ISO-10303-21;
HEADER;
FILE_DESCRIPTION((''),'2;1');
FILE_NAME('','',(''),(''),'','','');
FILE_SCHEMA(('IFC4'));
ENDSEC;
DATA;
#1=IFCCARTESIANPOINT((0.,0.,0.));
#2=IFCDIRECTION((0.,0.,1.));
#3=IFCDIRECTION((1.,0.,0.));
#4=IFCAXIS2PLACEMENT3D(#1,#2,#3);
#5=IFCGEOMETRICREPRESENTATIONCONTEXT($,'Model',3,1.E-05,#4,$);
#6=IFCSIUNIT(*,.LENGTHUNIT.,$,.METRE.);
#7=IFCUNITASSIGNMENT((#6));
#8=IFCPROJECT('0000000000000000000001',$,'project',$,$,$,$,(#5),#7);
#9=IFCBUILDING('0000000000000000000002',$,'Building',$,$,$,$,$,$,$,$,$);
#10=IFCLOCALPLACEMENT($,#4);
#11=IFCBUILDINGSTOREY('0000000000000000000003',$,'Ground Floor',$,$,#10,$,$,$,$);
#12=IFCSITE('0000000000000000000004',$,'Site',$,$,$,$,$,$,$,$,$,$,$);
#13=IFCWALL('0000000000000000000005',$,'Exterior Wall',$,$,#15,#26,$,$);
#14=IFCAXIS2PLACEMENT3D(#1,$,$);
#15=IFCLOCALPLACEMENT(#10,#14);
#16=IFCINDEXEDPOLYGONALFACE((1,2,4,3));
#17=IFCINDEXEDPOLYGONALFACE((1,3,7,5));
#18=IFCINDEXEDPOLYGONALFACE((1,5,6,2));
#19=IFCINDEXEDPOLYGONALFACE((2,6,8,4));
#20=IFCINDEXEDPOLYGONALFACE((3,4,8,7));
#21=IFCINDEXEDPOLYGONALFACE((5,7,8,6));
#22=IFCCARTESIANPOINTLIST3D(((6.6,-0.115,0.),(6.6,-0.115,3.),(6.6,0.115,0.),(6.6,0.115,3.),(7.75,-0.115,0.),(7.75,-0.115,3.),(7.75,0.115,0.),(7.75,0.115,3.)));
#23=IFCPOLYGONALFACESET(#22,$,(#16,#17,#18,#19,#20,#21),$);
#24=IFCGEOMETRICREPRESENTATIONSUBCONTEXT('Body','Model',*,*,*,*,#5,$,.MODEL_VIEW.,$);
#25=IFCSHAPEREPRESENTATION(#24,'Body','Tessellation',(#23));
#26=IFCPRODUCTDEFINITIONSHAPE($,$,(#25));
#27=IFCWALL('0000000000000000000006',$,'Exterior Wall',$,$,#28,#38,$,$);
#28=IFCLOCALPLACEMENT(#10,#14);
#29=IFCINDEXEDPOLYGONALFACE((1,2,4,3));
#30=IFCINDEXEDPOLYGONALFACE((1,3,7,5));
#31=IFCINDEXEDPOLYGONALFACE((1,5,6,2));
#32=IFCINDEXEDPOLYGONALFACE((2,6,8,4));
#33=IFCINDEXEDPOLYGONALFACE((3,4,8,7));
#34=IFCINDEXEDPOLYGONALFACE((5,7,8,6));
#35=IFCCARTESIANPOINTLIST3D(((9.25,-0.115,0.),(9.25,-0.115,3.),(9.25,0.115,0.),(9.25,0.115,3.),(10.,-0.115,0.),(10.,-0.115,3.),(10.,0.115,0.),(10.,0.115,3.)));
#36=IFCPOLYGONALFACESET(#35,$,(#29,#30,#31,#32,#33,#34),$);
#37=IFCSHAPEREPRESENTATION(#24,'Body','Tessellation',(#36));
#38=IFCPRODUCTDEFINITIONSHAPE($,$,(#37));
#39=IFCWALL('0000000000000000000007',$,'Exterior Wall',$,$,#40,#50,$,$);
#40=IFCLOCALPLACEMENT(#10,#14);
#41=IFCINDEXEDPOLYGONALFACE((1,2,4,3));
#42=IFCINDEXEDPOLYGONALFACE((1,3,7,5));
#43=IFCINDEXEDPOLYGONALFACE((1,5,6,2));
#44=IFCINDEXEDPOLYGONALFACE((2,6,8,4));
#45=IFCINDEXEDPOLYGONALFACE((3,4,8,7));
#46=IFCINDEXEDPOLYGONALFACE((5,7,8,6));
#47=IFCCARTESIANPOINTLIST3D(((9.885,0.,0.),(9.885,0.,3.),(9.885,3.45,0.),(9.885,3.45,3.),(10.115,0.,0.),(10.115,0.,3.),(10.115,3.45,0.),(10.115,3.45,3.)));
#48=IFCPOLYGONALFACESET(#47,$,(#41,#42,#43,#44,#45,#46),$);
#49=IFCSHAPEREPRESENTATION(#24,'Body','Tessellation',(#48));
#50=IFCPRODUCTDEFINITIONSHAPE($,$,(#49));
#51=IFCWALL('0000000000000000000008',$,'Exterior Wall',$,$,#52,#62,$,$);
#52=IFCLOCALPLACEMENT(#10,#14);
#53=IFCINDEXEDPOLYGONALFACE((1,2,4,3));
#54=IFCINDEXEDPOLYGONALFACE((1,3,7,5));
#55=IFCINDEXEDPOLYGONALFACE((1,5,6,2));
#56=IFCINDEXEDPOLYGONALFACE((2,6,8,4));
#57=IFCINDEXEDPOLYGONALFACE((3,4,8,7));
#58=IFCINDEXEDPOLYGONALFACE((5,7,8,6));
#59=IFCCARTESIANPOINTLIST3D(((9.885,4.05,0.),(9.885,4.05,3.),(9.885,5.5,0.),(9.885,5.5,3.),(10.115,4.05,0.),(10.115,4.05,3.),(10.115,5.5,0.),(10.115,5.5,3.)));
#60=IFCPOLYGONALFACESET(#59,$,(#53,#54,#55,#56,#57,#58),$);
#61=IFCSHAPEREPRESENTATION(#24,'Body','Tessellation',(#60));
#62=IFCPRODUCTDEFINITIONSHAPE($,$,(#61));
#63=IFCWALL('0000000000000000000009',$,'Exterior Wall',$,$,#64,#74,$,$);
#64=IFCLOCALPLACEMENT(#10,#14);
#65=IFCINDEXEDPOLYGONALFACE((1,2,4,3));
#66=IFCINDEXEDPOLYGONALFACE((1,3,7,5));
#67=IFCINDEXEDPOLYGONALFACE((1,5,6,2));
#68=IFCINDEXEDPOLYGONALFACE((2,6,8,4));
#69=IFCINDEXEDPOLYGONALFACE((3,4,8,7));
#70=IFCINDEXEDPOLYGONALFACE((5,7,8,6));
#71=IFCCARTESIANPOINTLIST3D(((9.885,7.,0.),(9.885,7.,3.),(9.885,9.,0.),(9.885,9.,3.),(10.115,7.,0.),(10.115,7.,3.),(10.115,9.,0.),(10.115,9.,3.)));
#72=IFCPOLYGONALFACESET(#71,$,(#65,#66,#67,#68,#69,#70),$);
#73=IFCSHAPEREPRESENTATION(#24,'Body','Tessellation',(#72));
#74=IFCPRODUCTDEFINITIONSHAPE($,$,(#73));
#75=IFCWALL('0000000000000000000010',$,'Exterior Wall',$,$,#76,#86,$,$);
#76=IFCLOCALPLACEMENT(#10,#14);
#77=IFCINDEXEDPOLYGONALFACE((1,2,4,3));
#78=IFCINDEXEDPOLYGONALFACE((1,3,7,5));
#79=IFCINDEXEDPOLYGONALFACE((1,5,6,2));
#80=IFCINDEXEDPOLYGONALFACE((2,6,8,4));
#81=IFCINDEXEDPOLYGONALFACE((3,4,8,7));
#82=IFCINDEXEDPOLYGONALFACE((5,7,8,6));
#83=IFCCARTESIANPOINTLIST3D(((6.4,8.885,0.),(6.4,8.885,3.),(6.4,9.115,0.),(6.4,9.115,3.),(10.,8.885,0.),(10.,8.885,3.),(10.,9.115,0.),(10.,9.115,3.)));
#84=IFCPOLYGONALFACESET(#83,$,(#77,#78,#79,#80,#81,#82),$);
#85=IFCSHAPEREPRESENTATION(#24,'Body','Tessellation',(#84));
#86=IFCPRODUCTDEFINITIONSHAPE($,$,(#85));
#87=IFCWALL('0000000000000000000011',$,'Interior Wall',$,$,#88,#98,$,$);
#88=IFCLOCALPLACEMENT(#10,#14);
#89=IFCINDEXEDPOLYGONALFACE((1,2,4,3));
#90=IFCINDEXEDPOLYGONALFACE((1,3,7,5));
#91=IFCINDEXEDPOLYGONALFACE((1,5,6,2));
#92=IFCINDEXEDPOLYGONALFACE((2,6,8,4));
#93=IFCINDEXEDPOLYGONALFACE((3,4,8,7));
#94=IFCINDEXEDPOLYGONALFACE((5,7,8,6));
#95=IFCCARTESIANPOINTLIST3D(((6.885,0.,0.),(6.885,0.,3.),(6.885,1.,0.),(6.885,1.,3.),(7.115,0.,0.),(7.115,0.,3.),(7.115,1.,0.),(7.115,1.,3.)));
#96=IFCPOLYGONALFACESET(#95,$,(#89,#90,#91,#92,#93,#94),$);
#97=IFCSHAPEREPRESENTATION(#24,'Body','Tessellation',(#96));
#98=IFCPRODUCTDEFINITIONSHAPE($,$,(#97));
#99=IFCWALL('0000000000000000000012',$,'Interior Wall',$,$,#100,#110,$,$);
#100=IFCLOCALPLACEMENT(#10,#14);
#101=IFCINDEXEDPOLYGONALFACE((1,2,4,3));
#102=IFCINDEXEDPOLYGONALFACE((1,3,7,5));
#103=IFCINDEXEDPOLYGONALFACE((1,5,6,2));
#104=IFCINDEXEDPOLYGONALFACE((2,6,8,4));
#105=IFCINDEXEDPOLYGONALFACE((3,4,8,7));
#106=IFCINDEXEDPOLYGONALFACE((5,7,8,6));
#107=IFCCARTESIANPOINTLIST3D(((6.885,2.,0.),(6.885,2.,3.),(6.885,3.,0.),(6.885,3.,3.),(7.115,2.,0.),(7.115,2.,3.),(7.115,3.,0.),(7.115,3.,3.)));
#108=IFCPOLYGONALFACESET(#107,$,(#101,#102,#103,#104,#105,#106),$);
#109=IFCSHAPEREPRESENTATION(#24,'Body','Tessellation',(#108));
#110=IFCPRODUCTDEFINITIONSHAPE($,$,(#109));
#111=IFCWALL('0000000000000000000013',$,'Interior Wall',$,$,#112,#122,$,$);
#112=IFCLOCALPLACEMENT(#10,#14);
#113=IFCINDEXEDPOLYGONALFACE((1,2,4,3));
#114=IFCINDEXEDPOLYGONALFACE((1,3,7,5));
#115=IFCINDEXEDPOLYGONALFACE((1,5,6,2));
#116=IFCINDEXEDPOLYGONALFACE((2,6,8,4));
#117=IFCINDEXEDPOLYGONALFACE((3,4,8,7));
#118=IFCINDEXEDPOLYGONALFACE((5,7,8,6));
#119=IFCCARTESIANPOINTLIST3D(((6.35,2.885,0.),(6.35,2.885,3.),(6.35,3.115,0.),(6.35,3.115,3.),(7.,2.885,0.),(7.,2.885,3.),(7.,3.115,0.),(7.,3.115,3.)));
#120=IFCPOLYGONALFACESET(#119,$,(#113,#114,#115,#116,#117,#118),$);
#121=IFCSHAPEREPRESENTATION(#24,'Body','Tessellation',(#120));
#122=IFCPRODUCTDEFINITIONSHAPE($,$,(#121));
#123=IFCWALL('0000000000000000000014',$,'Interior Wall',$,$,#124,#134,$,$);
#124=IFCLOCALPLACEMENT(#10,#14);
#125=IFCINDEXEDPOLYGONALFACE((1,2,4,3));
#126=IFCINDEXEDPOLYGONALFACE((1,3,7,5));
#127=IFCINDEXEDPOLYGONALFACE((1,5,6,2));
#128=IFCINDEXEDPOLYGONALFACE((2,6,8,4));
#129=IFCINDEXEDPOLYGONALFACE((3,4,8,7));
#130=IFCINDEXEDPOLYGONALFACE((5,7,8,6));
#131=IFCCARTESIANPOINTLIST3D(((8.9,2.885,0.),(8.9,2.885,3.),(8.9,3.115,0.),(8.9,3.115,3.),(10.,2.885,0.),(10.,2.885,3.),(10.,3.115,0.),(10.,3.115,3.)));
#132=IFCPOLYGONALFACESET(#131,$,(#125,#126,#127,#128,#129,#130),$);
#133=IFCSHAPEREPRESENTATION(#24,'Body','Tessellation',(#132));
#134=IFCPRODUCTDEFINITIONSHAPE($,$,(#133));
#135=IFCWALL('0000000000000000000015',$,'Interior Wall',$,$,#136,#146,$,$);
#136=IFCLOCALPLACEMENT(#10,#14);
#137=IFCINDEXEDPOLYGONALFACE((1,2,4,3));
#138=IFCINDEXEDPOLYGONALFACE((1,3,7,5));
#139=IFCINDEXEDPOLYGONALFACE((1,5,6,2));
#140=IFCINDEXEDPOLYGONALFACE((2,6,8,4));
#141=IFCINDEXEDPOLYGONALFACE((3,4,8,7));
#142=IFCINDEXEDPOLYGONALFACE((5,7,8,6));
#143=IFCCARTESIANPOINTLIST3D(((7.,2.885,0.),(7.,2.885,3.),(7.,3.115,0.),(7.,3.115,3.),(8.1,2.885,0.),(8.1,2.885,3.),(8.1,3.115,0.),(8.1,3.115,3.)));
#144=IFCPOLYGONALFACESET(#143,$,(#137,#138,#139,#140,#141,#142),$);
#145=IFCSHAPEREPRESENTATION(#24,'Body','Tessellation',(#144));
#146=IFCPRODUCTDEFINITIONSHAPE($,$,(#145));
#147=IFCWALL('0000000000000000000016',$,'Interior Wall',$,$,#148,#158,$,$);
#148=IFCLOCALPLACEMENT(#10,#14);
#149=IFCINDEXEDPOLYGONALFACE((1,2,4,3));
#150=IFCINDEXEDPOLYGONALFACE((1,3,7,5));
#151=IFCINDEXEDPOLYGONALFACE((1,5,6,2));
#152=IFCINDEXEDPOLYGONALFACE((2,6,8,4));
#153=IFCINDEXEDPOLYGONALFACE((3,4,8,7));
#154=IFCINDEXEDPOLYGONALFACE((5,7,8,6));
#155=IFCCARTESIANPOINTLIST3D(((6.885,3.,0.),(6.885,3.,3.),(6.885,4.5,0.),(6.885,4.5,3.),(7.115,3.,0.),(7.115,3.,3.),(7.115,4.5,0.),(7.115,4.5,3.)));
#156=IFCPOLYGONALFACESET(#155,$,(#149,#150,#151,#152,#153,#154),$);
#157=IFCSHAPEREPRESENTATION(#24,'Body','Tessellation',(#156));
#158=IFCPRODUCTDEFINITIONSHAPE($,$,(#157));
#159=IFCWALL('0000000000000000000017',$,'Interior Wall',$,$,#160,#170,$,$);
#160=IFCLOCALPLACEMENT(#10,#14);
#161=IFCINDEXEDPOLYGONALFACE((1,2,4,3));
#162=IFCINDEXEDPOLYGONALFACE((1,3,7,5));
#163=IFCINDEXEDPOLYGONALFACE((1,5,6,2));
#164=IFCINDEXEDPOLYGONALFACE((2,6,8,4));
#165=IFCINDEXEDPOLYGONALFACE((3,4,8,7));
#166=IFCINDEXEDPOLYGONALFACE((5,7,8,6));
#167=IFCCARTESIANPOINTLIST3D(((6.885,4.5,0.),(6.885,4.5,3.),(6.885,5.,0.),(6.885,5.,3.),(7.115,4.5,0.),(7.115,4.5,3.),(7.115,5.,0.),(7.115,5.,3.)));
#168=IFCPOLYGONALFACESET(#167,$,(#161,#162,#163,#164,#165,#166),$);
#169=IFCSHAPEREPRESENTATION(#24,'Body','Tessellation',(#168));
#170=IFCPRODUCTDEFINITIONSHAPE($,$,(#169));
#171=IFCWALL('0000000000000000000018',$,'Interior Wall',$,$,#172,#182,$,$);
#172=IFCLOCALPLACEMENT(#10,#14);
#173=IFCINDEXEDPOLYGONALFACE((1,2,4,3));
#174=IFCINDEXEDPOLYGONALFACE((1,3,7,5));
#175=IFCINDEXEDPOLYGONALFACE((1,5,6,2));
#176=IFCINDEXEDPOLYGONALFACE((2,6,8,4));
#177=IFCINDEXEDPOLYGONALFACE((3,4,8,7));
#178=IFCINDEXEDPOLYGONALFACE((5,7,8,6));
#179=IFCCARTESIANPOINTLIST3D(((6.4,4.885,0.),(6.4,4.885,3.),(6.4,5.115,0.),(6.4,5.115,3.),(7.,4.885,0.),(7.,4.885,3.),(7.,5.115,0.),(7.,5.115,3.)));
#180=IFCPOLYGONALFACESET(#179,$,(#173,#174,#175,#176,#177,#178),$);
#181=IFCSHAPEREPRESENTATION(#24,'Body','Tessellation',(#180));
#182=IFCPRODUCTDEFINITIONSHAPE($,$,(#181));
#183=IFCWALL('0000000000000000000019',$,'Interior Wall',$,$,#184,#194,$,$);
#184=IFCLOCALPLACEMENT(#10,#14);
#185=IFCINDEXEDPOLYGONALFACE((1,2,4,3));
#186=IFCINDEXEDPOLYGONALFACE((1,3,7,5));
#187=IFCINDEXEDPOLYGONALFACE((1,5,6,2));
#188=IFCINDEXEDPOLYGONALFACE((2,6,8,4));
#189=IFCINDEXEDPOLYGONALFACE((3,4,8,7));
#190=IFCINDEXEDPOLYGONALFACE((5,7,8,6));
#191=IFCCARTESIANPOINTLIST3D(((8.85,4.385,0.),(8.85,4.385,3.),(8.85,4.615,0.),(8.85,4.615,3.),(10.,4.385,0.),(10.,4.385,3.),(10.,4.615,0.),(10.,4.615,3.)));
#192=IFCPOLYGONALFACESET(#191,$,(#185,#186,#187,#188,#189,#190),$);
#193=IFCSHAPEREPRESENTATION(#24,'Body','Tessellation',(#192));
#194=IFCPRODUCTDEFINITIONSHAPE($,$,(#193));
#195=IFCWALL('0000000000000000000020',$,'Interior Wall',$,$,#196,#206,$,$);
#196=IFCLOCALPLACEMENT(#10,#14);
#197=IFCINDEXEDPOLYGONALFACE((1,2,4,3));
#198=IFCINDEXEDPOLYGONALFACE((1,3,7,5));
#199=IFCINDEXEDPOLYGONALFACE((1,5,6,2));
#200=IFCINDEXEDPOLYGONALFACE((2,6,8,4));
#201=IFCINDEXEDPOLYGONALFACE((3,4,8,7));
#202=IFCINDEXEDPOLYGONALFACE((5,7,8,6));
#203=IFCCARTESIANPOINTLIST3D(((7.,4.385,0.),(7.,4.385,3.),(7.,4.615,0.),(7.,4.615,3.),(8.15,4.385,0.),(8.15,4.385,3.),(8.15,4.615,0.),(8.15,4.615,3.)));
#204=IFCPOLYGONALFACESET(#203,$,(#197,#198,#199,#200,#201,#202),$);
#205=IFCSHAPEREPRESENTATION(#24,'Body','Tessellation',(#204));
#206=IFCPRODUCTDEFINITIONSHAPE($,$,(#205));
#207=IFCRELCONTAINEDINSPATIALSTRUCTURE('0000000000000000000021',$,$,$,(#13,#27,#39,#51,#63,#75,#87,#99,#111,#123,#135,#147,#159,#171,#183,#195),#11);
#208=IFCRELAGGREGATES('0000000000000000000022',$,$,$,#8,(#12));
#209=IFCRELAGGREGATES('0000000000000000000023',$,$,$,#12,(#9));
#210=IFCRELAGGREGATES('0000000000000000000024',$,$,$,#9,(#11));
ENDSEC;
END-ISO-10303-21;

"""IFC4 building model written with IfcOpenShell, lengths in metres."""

from ifc_helpers import new_model, si_unit, frame, origin_with_axes, place, context, subcontext, project, spatial, indexed_curve, outline, extrude, element, save


model = new_model("IFC4")

# Units and contexts
model_context = context("Model", 3, precision=1e-05, world=origin_with_axes())
body_context = subcontext(model_context, "Body", "Model", "MODEL_VIEW")
ifc_project = project(units=[si_unit("LENGTHUNIT", "METRE")], contexts=[model_context])

# Site, building, storey
site = spatial("IfcSite", under=ifc_project, Name="Site")
building = spatial("IfcBuilding", under=site, Name="Building")
storey_placement = place(None, origin_with_axes())
storey = spatial("IfcBuildingStorey", under=building, at=storey_placement, Name="Ground Floor")

# Walls
wall_1_placement = place(storey_placement, frame((6.6, 0.0, 0.0), z_axis=(0.0, 0.0, 1.0), x_axis=(1.0, 0.0, 0.0)))
element("IfcWall", 1, at=wall_1_placement, inside=storey, Name="Exterior Wall", context=body_context, shape_type="SweptSolid", body=[
    extrude(outline(indexed_curve([(0.0, 0.0), (0.0, 0.23), (1.15, 0.23), (1.15, 0.0), (0.0, 0.0)], self_intersect=False)), frame((0.0, -0.115, 0.0), z_axis=(0.0, 0.0, 1.0), x_axis=(1.0, 0.0, 0.0)), (0.0, 0.0, 1.0), 3.0),
])
wall_2_placement = place(storey_placement, frame((9.25, 0.0, 0.0), z_axis=(0.0, 0.0, 1.0), x_axis=(1.0, 0.0, 0.0)))
element("IfcWall", 2, at=wall_2_placement, inside=storey, Name="Exterior Wall", context=body_context, shape_type="SweptSolid", body=[
    extrude(outline(indexed_curve([(0.0, 0.0), (0.0, 0.23), (0.75, 0.23), (0.75, 0.0), (0.0, 0.0)], self_intersect=False)), frame((0.0, -0.115, 0.0), z_axis=(0.0, 0.0, 1.0), x_axis=(1.0, 0.0, 0.0)), (0.0, 0.0, 1.0), 3.0),
])
wall_3_placement = place(storey_placement, frame((10.0, 0.0, 0.0), z_axis=(0.0, 0.0, 1.0), x_axis=(0.0, 1.0, 0.0)))
element("IfcWall", 3, at=wall_3_placement, inside=storey, Name="Exterior Wall", context=body_context, shape_type="SweptSolid", body=[
    extrude(outline(indexed_curve([(0.0, 0.0), (0.0, 0.23), (3.45, 0.23), (3.45, 0.0), (0.0, 0.0)], self_intersect=False)), frame((0.0, -0.115, 0.0), z_axis=(0.0, 0.0, 1.0), x_axis=(1.0, 0.0, 0.0)), (0.0, 0.0, 1.0), 3.0),
])
wall_4_placement = place(storey_placement, frame((10.0, 4.05, 0.0), z_axis=(0.0, 0.0, 1.0), x_axis=(0.0, 1.0, 0.0)))
element("IfcWall", 4, at=wall_4_placement, inside=storey, Name="Exterior Wall", context=body_context, shape_type="SweptSolid", body=[
    extrude(outline(indexed_curve([(0.0, 0.0), (0.0, 0.23), (1.45, 0.23), (1.45, 0.0), (0.0, 0.0)], self_intersect=False)), frame((0.0, -0.115, 0.0), z_axis=(0.0, 0.0, 1.0), x_axis=(1.0, 0.0, 0.0)), (0.0, 0.0, 1.0), 3.0),
])
wall_5_placement = place(storey_placement, frame((10.0, 7.0, 0.0), z_axis=(0.0, 0.0, 1.0), x_axis=(0.0, 1.0, 0.0)))
element("IfcWall", 5, at=wall_5_placement, inside=storey, Name="Exterior Wall", context=body_context, shape_type="SweptSolid", body=[
    extrude(outline(indexed_curve([(0.0, 0.0), (0.0, 0.23), (2.0, 0.23), (2.0, 0.0), (0.0, 0.0)], self_intersect=False)), frame((0.0, -0.115, 0.0), z_axis=(0.0, 0.0, 1.0), x_axis=(1.0, 0.0, 0.0)), (0.0, 0.0, 1.0), 3.0),
])
wall_6_placement = place(storey_placement, frame((10.0, 9.0, 0.0), z_axis=(0.0, 0.0, 1.0), x_axis=(-1.0, 0.0, 0.0)))
element("IfcWall", 6, at=wall_6_placement, inside=storey, Name="Exterior Wall", context=body_context, shape_type="SweptSolid", body=[
    extrude(outline(indexed_curve([(0.0, 0.0), (0.0, 0.23), (3.6, 0.23), (3.6, 0.0), (0.0, 0.0)], self_intersect=False)), frame((0.0, -0.115, 0.0), z_axis=(0.0, 0.0, 1.0), x_axis=(1.0, 0.0, 0.0)), (0.0, 0.0, 1.0), 3.0),
])
for number, where, z_axis, x_axis, name in (
    (7, (7.0, 0.0, 0.0), (0.0, 0.0, 1.0), (0.0, 1.0, 0.0), "Interior Wall"),
    (8, (7.0, 2.0, 0.0), (0.0, 0.0, 1.0), (0.0, 1.0, 0.0), "Interior Wall"),
):
    element("IfcWall", number, at=place(storey_placement, frame(where, z_axis=z_axis, x_axis=x_axis)), inside=storey, Name=name, context=body_context, shape_type="SweptSolid", body=[
        extrude(outline(indexed_curve([(0.0, 0.0), (0.0, 0.23), (1.0, 0.23), (1.0, 0.0), (0.0, 0.0)], self_intersect=False)), frame((0.0, -0.115, 0.0), z_axis=(0.0, 0.0, 1.0), x_axis=(1.0, 0.0, 0.0)), (0.0, 0.0, 1.0), 3.0),
    ])
wall_7_placement = place(storey_placement, frame((7.0, 3.0, 0.0), z_axis=(0.0, 0.0, 1.0), x_axis=(-1.0, 0.0, 0.0)))
element("IfcWall", 9, at=wall_7_placement, inside=storey, Name="Interior Wall", context=body_context, shape_type="SweptSolid", body=[
    extrude(outline(indexed_curve([(0.0, 0.0), (0.0, 0.23), (0.65, 0.23), (0.65, 0.0), (0.0, 0.0)], self_intersect=False)), frame((0.0, -0.115, 0.0), z_axis=(0.0, 0.0, 1.0), x_axis=(1.0, 0.0, 0.0)), (0.0, 0.0, 1.0), 3.0),
])
for number, where, z_axis, x_axis, name in (
    (10, (10.0, 3.0, 0.0), (0.0, 0.0, 1.0), (-1.0, 0.0, 0.0), "Interior Wall"),
    (11, (8.1, 3.0, 0.0), (0.0, 0.0, 1.0), (-1.0, 0.0, 0.0), "Interior Wall"),
):
    element("IfcWall", number, at=place(storey_placement, frame(where, z_axis=z_axis, x_axis=x_axis)), inside=storey, Name=name, context=body_context, shape_type="SweptSolid", body=[
        extrude(outline(indexed_curve([(0.0, 0.0), (0.0, 0.23), (1.1, 0.23), (1.1, 0.0), (0.0, 0.0)], self_intersect=False)), frame((0.0, -0.115, 0.0), z_axis=(0.0, 0.0, 1.0), x_axis=(1.0, 0.0, 0.0)), (0.0, 0.0, 1.0), 3.0),
    ])
wall_8_placement = place(storey_placement, frame((7.0, 3.0, 0.0), z_axis=(0.0, 0.0, 1.0), x_axis=(0.0, 1.0, 0.0)))
element("IfcWall", 12, at=wall_8_placement, inside=storey, Name="Interior Wall", context=body_context, shape_type="SweptSolid", body=[
    extrude(outline(indexed_curve([(0.0, 0.0), (0.0, 0.23), (1.5, 0.23), (1.5, 0.0), (0.0, 0.0)], self_intersect=False)), frame((0.0, -0.115, 0.0), z_axis=(0.0, 0.0, 1.0), x_axis=(1.0, 0.0, 0.0)), (0.0, 0.0, 1.0), 3.0),
])
wall_9_placement = place(storey_placement, frame((7.0, 4.5, 0.0), z_axis=(0.0, 0.0, 1.0), x_axis=(0.0, 1.0, 0.0)))
element("IfcWall", 13, at=wall_9_placement, inside=storey, Name="Interior Wall", context=body_context, shape_type="SweptSolid", body=[
    extrude(outline(indexed_curve([(0.0, 0.0), (0.0, 0.23), (0.5, 0.23), (0.5, 0.0), (0.0, 0.0)], self_intersect=False)), frame((0.0, -0.115, 0.0), z_axis=(0.0, 0.0, 1.0), x_axis=(1.0, 0.0, 0.0)), (0.0, 0.0, 1.0), 3.0),
])
wall_10_placement = place(storey_placement, frame((7.0, 5.0, 0.0), z_axis=(0.0, 0.0, 1.0), x_axis=(-1.0, 0.0, 0.0)))
element("IfcWall", 14, at=wall_10_placement, inside=storey, Name="Interior Wall", context=body_context, shape_type="SweptSolid", body=[
    extrude(outline(indexed_curve([(0.0, 0.0), (0.0, 0.23), (0.6, 0.23), (0.6, 0.0), (0.0, 0.0)], self_intersect=False)), frame((0.0, -0.115, 0.0), z_axis=(0.0, 0.0, 1.0), x_axis=(1.0, 0.0, 0.0)), (0.0, 0.0, 1.0), 3.0),
])
for number, where, z_axis, x_axis, name in (
    (15, (10.0, 4.5, 0.0), (0.0, 0.0, 1.0), (-1.0, 0.0, 0.0), "Interior Wall"),
    (16, (8.15, 4.5, 0.0), (0.0, 0.0, 1.0), (-1.0, 0.0, 0.0), "Interior Wall"),
):
    element("IfcWall", number, at=place(storey_placement, frame(where, z_axis=z_axis, x_axis=x_axis)), inside=storey, Name=name, context=body_context, shape_type="SweptSolid", body=[
        extrude(outline(indexed_curve([(0.0, 0.0), (0.0, 0.23), (1.15, 0.23), (1.15, 0.0), (0.0, 0.0)], self_intersect=False)), frame((0.0, -0.115, 0.0), z_axis=(0.0, 0.0, 1.0), x_axis=(1.0, 0.0, 0.0)), (0.0, 0.0, 1.0), 3.0),
    ])

save(model, "model.ifc")
